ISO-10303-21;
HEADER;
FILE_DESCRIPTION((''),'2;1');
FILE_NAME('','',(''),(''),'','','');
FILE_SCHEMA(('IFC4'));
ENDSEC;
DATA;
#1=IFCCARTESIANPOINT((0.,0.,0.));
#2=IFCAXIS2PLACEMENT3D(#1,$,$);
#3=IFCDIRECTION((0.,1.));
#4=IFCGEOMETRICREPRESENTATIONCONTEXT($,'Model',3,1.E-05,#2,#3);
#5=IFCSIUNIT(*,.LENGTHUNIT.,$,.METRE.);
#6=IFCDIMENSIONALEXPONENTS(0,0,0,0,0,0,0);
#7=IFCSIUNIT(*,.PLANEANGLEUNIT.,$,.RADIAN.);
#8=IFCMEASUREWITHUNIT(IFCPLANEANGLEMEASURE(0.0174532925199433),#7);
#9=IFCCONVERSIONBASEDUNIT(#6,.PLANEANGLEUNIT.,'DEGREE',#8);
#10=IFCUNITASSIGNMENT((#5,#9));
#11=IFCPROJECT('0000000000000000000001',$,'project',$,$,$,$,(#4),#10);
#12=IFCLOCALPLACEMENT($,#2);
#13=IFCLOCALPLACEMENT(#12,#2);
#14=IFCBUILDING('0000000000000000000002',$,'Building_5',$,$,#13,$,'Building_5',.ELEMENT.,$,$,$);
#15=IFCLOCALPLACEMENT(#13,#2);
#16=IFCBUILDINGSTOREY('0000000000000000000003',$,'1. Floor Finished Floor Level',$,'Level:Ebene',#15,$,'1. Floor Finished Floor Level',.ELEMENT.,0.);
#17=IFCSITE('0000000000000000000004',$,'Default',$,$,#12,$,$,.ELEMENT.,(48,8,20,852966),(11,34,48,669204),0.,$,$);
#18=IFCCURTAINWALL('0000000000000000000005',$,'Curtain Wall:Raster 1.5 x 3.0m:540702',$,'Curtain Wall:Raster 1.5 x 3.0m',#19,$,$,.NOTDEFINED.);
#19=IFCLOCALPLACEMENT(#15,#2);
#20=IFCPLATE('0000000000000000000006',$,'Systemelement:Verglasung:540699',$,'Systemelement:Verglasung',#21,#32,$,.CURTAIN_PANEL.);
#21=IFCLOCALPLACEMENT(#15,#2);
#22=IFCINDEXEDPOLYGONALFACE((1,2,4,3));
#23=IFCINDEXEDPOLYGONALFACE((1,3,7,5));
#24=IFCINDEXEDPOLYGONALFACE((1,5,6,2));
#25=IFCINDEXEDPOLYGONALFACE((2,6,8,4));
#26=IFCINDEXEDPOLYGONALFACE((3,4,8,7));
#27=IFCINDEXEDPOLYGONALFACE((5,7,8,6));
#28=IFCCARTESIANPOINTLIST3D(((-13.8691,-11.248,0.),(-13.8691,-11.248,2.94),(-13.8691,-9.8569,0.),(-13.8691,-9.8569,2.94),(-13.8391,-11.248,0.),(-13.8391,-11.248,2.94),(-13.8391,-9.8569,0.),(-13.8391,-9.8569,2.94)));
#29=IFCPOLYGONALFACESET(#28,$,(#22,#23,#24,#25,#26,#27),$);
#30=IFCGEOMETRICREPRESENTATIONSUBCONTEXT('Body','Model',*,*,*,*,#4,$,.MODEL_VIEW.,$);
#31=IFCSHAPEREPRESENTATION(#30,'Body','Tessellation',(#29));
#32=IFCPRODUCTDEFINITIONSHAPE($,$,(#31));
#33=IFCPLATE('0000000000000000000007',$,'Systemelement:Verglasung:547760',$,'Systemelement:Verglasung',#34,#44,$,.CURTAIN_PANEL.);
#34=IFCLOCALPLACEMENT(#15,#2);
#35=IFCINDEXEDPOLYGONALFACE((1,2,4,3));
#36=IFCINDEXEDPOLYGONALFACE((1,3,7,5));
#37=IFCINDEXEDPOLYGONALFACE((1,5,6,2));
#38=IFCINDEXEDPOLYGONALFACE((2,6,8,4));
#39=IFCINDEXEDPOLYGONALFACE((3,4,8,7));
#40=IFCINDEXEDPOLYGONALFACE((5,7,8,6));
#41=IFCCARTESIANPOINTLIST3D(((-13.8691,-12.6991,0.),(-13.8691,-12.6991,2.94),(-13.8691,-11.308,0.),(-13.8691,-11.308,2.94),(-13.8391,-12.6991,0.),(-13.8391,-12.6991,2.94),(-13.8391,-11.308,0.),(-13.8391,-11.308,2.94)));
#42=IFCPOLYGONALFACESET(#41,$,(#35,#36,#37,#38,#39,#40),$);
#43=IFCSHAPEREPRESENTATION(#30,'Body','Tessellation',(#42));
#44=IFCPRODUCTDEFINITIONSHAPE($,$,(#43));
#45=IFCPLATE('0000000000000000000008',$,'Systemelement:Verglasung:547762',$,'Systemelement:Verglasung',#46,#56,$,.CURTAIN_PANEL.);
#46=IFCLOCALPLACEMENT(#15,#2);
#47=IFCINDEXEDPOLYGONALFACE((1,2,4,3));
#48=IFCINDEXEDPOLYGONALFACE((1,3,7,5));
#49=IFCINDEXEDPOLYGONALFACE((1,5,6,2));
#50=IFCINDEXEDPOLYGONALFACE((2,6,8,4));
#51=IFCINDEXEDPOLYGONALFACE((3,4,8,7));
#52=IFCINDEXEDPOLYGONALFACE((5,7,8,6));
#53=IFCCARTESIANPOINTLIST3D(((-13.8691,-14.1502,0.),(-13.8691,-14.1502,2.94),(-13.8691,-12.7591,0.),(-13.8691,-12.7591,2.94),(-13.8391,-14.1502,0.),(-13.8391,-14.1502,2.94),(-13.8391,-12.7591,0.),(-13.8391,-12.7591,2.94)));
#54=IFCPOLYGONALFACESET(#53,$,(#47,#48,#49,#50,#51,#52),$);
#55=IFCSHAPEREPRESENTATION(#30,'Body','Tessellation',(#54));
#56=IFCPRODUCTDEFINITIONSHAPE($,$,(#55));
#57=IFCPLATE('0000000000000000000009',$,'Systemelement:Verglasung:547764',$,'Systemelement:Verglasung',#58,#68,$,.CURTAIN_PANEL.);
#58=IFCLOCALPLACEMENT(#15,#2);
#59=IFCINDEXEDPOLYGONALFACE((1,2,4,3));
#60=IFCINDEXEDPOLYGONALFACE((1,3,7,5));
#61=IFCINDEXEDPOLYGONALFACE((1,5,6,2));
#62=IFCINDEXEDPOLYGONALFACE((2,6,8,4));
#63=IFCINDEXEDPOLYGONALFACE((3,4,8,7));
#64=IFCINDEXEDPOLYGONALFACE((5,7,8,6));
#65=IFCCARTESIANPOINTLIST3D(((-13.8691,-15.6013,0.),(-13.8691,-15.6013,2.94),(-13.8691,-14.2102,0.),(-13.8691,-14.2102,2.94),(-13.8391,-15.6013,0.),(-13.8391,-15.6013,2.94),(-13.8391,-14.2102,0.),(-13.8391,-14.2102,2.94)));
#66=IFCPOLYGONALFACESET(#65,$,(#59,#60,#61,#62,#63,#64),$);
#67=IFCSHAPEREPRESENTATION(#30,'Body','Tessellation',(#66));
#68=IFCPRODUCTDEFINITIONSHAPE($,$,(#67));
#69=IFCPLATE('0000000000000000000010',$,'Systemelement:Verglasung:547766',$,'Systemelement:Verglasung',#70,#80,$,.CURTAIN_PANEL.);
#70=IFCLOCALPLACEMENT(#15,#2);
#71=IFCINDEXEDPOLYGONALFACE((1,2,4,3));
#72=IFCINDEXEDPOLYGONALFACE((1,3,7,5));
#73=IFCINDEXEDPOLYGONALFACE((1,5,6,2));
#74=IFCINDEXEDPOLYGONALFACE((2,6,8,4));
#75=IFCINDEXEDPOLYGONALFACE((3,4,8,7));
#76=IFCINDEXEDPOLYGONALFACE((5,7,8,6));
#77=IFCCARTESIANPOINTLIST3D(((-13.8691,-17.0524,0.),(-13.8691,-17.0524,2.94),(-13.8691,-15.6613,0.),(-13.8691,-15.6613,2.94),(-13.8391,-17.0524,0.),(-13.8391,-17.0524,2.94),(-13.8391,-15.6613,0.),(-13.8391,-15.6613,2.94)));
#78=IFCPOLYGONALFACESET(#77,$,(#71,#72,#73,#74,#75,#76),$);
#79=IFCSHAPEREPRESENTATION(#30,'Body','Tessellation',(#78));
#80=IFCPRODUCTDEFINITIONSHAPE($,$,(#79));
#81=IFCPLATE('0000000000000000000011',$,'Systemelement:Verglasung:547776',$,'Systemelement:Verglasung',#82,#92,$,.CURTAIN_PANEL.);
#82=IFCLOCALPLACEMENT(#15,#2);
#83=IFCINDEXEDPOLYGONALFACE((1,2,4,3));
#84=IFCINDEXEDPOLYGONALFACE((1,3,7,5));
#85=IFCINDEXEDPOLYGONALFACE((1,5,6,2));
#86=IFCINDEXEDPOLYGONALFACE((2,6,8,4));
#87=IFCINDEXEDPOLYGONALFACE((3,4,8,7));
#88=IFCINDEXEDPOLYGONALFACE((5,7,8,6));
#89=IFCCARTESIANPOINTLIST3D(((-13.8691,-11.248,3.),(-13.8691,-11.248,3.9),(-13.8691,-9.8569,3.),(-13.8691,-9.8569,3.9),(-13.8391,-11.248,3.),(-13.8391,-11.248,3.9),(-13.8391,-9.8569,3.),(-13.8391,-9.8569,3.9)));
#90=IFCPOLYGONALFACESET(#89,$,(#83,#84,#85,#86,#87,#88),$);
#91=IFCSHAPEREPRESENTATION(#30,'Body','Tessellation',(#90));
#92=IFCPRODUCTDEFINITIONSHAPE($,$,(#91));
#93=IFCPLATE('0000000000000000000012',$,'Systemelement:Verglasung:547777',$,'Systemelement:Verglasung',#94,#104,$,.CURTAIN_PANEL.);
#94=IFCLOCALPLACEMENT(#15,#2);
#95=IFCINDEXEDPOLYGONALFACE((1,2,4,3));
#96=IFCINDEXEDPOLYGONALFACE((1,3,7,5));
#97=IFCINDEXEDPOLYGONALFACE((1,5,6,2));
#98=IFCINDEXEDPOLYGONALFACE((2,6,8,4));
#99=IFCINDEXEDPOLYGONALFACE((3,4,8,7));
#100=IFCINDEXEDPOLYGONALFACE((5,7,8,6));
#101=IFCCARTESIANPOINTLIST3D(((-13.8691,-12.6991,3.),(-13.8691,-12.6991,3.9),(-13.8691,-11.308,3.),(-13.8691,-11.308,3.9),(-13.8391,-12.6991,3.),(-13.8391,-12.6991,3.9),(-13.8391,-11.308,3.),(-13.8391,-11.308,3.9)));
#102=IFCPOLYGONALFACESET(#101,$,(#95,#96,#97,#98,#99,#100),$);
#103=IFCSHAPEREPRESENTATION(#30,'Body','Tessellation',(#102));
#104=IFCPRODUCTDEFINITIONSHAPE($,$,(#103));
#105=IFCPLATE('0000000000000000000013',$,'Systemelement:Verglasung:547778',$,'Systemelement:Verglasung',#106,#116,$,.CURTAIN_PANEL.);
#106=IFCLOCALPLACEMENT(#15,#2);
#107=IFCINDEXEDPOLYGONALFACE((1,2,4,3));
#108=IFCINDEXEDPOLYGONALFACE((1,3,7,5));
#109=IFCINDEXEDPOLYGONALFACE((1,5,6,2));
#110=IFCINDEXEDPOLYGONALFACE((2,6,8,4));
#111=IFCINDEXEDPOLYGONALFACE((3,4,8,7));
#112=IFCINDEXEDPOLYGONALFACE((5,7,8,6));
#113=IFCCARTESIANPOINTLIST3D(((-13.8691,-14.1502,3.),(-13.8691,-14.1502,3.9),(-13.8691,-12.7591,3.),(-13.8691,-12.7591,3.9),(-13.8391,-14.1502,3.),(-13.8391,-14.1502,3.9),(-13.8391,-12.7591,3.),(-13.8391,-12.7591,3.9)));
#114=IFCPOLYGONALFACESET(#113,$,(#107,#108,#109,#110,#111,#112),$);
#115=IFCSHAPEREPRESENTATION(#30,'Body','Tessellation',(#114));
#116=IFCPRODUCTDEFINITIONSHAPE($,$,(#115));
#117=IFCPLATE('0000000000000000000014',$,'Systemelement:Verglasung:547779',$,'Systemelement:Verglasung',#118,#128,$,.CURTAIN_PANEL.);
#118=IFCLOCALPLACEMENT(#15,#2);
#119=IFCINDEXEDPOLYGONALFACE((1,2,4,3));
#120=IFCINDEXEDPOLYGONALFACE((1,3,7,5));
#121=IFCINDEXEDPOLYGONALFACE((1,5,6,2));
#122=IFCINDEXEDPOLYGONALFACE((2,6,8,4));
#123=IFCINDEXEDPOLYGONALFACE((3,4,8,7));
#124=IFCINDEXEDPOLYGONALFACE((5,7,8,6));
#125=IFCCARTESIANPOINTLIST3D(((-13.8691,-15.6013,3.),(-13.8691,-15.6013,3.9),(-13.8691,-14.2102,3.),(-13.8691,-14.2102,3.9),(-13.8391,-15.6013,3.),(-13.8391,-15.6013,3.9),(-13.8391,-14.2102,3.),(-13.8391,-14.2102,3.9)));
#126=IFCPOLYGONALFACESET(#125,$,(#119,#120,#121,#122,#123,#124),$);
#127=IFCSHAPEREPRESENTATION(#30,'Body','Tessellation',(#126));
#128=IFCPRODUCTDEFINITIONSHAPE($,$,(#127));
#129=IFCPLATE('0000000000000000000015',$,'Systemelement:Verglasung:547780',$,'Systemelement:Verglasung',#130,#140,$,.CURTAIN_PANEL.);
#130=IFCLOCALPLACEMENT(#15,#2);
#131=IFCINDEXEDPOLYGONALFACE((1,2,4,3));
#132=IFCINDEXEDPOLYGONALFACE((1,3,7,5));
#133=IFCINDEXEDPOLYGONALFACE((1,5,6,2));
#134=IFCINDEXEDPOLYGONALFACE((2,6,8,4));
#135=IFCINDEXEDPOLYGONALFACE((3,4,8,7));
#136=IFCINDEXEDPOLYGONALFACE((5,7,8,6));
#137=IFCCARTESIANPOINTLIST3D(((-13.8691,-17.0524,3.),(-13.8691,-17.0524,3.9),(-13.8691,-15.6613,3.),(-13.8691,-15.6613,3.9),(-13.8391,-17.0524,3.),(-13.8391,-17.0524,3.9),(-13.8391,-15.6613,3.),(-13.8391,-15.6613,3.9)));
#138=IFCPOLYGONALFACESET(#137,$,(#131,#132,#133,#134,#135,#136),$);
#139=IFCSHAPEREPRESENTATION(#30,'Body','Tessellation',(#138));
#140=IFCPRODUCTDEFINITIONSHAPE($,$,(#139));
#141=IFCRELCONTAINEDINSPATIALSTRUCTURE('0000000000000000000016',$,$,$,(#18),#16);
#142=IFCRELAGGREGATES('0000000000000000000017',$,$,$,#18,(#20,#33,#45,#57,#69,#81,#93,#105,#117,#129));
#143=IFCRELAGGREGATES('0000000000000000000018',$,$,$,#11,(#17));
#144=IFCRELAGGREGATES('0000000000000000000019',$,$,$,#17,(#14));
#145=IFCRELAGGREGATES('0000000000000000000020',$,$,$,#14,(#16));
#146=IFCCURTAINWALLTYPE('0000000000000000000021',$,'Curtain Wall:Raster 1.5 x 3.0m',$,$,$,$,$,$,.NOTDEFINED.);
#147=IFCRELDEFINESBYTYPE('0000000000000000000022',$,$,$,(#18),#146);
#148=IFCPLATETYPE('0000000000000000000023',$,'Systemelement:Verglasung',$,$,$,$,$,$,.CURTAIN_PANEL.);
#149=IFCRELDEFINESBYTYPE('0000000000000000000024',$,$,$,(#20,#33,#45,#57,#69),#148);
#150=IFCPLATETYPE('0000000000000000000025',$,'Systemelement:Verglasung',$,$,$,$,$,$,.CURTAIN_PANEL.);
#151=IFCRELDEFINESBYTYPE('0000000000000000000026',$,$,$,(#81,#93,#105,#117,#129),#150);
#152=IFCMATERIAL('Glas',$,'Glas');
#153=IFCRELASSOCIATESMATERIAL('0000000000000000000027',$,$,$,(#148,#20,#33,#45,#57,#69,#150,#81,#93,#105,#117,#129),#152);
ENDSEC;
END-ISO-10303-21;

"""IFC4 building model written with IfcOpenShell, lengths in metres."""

from ifc_helpers import new_model, entity, si_unit, converted_unit, direction, frame, origin, place, context, subcontext, project, spatial, indexed_curve, outline, extrude, source, transform, mapped, material, type_object, type_shapes, element, aggregate, save


model = new_model("IFC4")

# Units and contexts
model_context = context("Model", 3, precision=1e-05, world=origin(), true_north=direction((0.0, 1.0)))
body_context = subcontext(model_context, "Body", "Model", "MODEL_VIEW")
ifc_project = project(units=[si_unit("LENGTHUNIT", "METRE"), converted_unit("PLANEANGLEUNIT", "DEGREE", entity("IfcPlaneAngleMeasure", 0.0174532925199433), si_unit("PLANEANGLEUNIT", "RADIAN"), dimensions=[0, 0, 0, 0, 0, 0, 0])], contexts=[model_context])

# Site, building, storey
site_placement = place(None, origin())
site = spatial("IfcSite", under=ifc_project, at=site_placement, Name="Default", CompositionType="ELEMENT", RefLatitude=(48, 8, 20, 852966), RefLongitude=(11, 34, 48, 669204), RefElevation=0.0)
building_placement = place(site_placement, origin())
building = spatial("IfcBuilding", under=site, at=building_placement, Name="Building_5", LongName="Building_5", CompositionType="ELEMENT")
storey_placement = place(building_placement, origin())
storey = spatial("IfcBuildingStorey", under=building, at=storey_placement, Name="1. Floor Finished Floor Level", ObjectType="Level:Ebene", LongName="1. Floor Finished Floor Level", CompositionType="ELEMENT", Elevation=0.0)

# Curtain wall, plates
curtain_wall_type = type_object("IfcCurtainWallType", Name="Curtain Wall:Raster 1.5 x 3.0m", PredefinedType="NOTDEFINED")
curtain_wall_placement = place(storey_placement, origin())
curtain_wall = element("IfcCurtainWall", 1, at=curtain_wall_placement, inside=storey, type_object=curtain_wall_type, Name="Curtain Wall:Raster 1.5 x 3.0m:540702", ObjectType="Curtain Wall:Raster 1.5 x 3.0m", PredefinedType="NOTDEFINED")
ifc_material_1 = material(Name="Glas", Category="Glas")
plate_type_1 = type_object("IfcPlateType", Name="Systemelement:Verglasung", PredefinedType="CURTAIN_PANEL", material=ifc_material_1)
shared_shape_1 = source(origin(), body_context, "Body", "SweptSolid", [
    extrude(outline(indexed_curve([(-0.015, -0.6956), (0.015, -0.6956), (0.015, 0.6956), (-0.015, 0.6956), (-0.015, -0.6956)], self_intersect=False)), frame((0.0, 0.0, 0.0), z_axis=(0.0, 0.0, 1.0), x_axis=(0.0, 1.0, 0.0)), (0.0, 0.0, 1.0), 2.94),
])
type_shapes(plate_type_1, [shared_shape_1])
plate_1_placement = place(curtain_wall_placement, frame((-13.8541, -10.5524, 0.0), z_axis=(0.0, 0.0, 1.0), x_axis=(0.0, -1.0, 0.0)))
plate_1 = element("IfcPlate", 2, at=plate_1_placement, type_object=plate_type_1, material=ifc_material_1, Name="Systemelement:Verglasung:540699", ObjectType="Systemelement:Verglasung", PredefinedType="CURTAIN_PANEL", context=body_context, shape_type="MappedRepresentation", body=[
    mapped(shared_shape_1, transform((0.0, 0.0, 0.0), scale=1.0)),
])
plate_2_placement = place(curtain_wall_placement, frame((-13.8541, -12.0035, 0.0), z_axis=(0.0, 0.0, 1.0), x_axis=(0.0, -1.0, 0.0)))
plate_2 = element("IfcPlate", 3, at=plate_2_placement, type_object=plate_type_1, material=ifc_material_1, Name="Systemelement:Verglasung:547760", ObjectType="Systemelement:Verglasung", PredefinedType="CURTAIN_PANEL", context=body_context, shape_type="MappedRepresentation", body=[
    mapped(shared_shape_1, transform((0.0, 0.0, 0.0), scale=1.0)),
])
plate_3_placement = place(curtain_wall_placement, frame((-13.8541, -13.4546, 0.0), z_axis=(0.0, 0.0, 1.0), x_axis=(0.0, -1.0, 0.0)))
plate_3 = element("IfcPlate", 4, at=plate_3_placement, type_object=plate_type_1, material=ifc_material_1, Name="Systemelement:Verglasung:547762", ObjectType="Systemelement:Verglasung", PredefinedType="CURTAIN_PANEL", context=body_context, shape_type="MappedRepresentation", body=[
    mapped(shared_shape_1, transform((0.0, 0.0, 0.0), scale=1.0)),
])
plate_4_placement = place(curtain_wall_placement, frame((-13.8541, -14.9057, 0.0), z_axis=(0.0, 0.0, 1.0), x_axis=(0.0, -1.0, 0.0)))
plate_4 = element("IfcPlate", 5, at=plate_4_placement, type_object=plate_type_1, material=ifc_material_1, Name="Systemelement:Verglasung:547764", ObjectType="Systemelement:Verglasung", PredefinedType="CURTAIN_PANEL", context=body_context, shape_type="MappedRepresentation", body=[
    mapped(shared_shape_1, transform((0.0, 0.0, 0.0), scale=1.0)),
])
plate_5_placement = place(curtain_wall_placement, frame((-13.8541, -16.3569, 0.0), z_axis=(0.0, 0.0, 1.0), x_axis=(0.0, -1.0, 0.0)))
plate_5 = element("IfcPlate", 6, at=plate_5_placement, type_object=plate_type_1, material=ifc_material_1, Name="Systemelement:Verglasung:547766", ObjectType="Systemelement:Verglasung", PredefinedType="CURTAIN_PANEL", context=body_context, shape_type="MappedRepresentation", body=[
    mapped(shared_shape_1, transform((0.0, 0.0, 0.0), scale=1.0)),
])
plate_type_2 = type_object("IfcPlateType", Name="Systemelement:Verglasung", PredefinedType="CURTAIN_PANEL", material=ifc_material_1)
shared_shape_2 = source(origin(), body_context, "Body", "SweptSolid", [
    extrude(outline(indexed_curve([(-0.015, -0.6956), (0.015, -0.6956), (0.015, 0.6956), (-0.015, 0.6956), (-0.015, -0.6956)], self_intersect=False)), frame((0.0, 0.0, 0.0), z_axis=(0.0, 0.0, 1.0), x_axis=(0.0, 1.0, 0.0)), (0.0, 0.0, 1.0), 0.9),
])
type_shapes(plate_type_2, [shared_shape_2])
plate_6_placement = place(curtain_wall_placement, frame((-13.8541, -10.5524, 3.0), z_axis=(0.0, 0.0, 1.0), x_axis=(0.0, -1.0, 0.0)))
plate_6 = element("IfcPlate", 7, at=plate_6_placement, type_object=plate_type_2, material=ifc_material_1, Name="Systemelement:Verglasung:547776", ObjectType="Systemelement:Verglasung", PredefinedType="CURTAIN_PANEL", context=body_context, shape_type="MappedRepresentation", body=[
    mapped(shared_shape_2, transform((0.0, 0.0, 0.0), scale=1.0)),
])
plate_7_placement = place(curtain_wall_placement, frame((-13.8541, -12.0035, 3.0), z_axis=(0.0, 0.0, 1.0), x_axis=(0.0, -1.0, 0.0)))
plate_7 = element("IfcPlate", 8, at=plate_7_placement, type_object=plate_type_2, material=ifc_material_1, Name="Systemelement:Verglasung:547777", ObjectType="Systemelement:Verglasung", PredefinedType="CURTAIN_PANEL", context=body_context, shape_type="MappedRepresentation", body=[
    mapped(shared_shape_2, transform((0.0, 0.0, 0.0), scale=1.0)),
])
plate_8_placement = place(curtain_wall_placement, frame((-13.8541, -13.4546, 3.0), z_axis=(0.0, 0.0, 1.0), x_axis=(0.0, -1.0, 0.0)))
plate_8 = element("IfcPlate", 9, at=plate_8_placement, type_object=plate_type_2, material=ifc_material_1, Name="Systemelement:Verglasung:547778", ObjectType="Systemelement:Verglasung", PredefinedType="CURTAIN_PANEL", context=body_context, shape_type="MappedRepresentation", body=[
    mapped(shared_shape_2, transform((0.0, 0.0, 0.0), scale=1.0)),
])
plate_9_placement = place(curtain_wall_placement, frame((-13.8541, -14.9057, 3.0), z_axis=(0.0, 0.0, 1.0), x_axis=(0.0, -1.0, 0.0)))
plate_9 = element("IfcPlate", 10, at=plate_9_placement, type_object=plate_type_2, material=ifc_material_1, Name="Systemelement:Verglasung:547779", ObjectType="Systemelement:Verglasung", PredefinedType="CURTAIN_PANEL", context=body_context, shape_type="MappedRepresentation", body=[
    mapped(shared_shape_2, transform((0.0, 0.0, 0.0), scale=1.0)),
])
plate_10_placement = place(curtain_wall_placement, frame((-13.8541, -16.3569, 3.0), z_axis=(0.0, 0.0, 1.0), x_axis=(0.0, -1.0, 0.0)))
plate_10 = element("IfcPlate", 11, at=plate_10_placement, type_object=plate_type_2, material=ifc_material_1, Name="Systemelement:Verglasung:547780", ObjectType="Systemelement:Verglasung", PredefinedType="CURTAIN_PANEL", context=body_context, shape_type="MappedRepresentation", body=[
    mapped(shared_shape_2, transform((0.0, 0.0, 0.0), scale=1.0)),
])
aggregate(curtain_wall, [plate_1, plate_2, plate_3, plate_4, plate_5, plate_6, plate_7, plate_8, plate_9, plate_10])

save(model, "model.ifc")
